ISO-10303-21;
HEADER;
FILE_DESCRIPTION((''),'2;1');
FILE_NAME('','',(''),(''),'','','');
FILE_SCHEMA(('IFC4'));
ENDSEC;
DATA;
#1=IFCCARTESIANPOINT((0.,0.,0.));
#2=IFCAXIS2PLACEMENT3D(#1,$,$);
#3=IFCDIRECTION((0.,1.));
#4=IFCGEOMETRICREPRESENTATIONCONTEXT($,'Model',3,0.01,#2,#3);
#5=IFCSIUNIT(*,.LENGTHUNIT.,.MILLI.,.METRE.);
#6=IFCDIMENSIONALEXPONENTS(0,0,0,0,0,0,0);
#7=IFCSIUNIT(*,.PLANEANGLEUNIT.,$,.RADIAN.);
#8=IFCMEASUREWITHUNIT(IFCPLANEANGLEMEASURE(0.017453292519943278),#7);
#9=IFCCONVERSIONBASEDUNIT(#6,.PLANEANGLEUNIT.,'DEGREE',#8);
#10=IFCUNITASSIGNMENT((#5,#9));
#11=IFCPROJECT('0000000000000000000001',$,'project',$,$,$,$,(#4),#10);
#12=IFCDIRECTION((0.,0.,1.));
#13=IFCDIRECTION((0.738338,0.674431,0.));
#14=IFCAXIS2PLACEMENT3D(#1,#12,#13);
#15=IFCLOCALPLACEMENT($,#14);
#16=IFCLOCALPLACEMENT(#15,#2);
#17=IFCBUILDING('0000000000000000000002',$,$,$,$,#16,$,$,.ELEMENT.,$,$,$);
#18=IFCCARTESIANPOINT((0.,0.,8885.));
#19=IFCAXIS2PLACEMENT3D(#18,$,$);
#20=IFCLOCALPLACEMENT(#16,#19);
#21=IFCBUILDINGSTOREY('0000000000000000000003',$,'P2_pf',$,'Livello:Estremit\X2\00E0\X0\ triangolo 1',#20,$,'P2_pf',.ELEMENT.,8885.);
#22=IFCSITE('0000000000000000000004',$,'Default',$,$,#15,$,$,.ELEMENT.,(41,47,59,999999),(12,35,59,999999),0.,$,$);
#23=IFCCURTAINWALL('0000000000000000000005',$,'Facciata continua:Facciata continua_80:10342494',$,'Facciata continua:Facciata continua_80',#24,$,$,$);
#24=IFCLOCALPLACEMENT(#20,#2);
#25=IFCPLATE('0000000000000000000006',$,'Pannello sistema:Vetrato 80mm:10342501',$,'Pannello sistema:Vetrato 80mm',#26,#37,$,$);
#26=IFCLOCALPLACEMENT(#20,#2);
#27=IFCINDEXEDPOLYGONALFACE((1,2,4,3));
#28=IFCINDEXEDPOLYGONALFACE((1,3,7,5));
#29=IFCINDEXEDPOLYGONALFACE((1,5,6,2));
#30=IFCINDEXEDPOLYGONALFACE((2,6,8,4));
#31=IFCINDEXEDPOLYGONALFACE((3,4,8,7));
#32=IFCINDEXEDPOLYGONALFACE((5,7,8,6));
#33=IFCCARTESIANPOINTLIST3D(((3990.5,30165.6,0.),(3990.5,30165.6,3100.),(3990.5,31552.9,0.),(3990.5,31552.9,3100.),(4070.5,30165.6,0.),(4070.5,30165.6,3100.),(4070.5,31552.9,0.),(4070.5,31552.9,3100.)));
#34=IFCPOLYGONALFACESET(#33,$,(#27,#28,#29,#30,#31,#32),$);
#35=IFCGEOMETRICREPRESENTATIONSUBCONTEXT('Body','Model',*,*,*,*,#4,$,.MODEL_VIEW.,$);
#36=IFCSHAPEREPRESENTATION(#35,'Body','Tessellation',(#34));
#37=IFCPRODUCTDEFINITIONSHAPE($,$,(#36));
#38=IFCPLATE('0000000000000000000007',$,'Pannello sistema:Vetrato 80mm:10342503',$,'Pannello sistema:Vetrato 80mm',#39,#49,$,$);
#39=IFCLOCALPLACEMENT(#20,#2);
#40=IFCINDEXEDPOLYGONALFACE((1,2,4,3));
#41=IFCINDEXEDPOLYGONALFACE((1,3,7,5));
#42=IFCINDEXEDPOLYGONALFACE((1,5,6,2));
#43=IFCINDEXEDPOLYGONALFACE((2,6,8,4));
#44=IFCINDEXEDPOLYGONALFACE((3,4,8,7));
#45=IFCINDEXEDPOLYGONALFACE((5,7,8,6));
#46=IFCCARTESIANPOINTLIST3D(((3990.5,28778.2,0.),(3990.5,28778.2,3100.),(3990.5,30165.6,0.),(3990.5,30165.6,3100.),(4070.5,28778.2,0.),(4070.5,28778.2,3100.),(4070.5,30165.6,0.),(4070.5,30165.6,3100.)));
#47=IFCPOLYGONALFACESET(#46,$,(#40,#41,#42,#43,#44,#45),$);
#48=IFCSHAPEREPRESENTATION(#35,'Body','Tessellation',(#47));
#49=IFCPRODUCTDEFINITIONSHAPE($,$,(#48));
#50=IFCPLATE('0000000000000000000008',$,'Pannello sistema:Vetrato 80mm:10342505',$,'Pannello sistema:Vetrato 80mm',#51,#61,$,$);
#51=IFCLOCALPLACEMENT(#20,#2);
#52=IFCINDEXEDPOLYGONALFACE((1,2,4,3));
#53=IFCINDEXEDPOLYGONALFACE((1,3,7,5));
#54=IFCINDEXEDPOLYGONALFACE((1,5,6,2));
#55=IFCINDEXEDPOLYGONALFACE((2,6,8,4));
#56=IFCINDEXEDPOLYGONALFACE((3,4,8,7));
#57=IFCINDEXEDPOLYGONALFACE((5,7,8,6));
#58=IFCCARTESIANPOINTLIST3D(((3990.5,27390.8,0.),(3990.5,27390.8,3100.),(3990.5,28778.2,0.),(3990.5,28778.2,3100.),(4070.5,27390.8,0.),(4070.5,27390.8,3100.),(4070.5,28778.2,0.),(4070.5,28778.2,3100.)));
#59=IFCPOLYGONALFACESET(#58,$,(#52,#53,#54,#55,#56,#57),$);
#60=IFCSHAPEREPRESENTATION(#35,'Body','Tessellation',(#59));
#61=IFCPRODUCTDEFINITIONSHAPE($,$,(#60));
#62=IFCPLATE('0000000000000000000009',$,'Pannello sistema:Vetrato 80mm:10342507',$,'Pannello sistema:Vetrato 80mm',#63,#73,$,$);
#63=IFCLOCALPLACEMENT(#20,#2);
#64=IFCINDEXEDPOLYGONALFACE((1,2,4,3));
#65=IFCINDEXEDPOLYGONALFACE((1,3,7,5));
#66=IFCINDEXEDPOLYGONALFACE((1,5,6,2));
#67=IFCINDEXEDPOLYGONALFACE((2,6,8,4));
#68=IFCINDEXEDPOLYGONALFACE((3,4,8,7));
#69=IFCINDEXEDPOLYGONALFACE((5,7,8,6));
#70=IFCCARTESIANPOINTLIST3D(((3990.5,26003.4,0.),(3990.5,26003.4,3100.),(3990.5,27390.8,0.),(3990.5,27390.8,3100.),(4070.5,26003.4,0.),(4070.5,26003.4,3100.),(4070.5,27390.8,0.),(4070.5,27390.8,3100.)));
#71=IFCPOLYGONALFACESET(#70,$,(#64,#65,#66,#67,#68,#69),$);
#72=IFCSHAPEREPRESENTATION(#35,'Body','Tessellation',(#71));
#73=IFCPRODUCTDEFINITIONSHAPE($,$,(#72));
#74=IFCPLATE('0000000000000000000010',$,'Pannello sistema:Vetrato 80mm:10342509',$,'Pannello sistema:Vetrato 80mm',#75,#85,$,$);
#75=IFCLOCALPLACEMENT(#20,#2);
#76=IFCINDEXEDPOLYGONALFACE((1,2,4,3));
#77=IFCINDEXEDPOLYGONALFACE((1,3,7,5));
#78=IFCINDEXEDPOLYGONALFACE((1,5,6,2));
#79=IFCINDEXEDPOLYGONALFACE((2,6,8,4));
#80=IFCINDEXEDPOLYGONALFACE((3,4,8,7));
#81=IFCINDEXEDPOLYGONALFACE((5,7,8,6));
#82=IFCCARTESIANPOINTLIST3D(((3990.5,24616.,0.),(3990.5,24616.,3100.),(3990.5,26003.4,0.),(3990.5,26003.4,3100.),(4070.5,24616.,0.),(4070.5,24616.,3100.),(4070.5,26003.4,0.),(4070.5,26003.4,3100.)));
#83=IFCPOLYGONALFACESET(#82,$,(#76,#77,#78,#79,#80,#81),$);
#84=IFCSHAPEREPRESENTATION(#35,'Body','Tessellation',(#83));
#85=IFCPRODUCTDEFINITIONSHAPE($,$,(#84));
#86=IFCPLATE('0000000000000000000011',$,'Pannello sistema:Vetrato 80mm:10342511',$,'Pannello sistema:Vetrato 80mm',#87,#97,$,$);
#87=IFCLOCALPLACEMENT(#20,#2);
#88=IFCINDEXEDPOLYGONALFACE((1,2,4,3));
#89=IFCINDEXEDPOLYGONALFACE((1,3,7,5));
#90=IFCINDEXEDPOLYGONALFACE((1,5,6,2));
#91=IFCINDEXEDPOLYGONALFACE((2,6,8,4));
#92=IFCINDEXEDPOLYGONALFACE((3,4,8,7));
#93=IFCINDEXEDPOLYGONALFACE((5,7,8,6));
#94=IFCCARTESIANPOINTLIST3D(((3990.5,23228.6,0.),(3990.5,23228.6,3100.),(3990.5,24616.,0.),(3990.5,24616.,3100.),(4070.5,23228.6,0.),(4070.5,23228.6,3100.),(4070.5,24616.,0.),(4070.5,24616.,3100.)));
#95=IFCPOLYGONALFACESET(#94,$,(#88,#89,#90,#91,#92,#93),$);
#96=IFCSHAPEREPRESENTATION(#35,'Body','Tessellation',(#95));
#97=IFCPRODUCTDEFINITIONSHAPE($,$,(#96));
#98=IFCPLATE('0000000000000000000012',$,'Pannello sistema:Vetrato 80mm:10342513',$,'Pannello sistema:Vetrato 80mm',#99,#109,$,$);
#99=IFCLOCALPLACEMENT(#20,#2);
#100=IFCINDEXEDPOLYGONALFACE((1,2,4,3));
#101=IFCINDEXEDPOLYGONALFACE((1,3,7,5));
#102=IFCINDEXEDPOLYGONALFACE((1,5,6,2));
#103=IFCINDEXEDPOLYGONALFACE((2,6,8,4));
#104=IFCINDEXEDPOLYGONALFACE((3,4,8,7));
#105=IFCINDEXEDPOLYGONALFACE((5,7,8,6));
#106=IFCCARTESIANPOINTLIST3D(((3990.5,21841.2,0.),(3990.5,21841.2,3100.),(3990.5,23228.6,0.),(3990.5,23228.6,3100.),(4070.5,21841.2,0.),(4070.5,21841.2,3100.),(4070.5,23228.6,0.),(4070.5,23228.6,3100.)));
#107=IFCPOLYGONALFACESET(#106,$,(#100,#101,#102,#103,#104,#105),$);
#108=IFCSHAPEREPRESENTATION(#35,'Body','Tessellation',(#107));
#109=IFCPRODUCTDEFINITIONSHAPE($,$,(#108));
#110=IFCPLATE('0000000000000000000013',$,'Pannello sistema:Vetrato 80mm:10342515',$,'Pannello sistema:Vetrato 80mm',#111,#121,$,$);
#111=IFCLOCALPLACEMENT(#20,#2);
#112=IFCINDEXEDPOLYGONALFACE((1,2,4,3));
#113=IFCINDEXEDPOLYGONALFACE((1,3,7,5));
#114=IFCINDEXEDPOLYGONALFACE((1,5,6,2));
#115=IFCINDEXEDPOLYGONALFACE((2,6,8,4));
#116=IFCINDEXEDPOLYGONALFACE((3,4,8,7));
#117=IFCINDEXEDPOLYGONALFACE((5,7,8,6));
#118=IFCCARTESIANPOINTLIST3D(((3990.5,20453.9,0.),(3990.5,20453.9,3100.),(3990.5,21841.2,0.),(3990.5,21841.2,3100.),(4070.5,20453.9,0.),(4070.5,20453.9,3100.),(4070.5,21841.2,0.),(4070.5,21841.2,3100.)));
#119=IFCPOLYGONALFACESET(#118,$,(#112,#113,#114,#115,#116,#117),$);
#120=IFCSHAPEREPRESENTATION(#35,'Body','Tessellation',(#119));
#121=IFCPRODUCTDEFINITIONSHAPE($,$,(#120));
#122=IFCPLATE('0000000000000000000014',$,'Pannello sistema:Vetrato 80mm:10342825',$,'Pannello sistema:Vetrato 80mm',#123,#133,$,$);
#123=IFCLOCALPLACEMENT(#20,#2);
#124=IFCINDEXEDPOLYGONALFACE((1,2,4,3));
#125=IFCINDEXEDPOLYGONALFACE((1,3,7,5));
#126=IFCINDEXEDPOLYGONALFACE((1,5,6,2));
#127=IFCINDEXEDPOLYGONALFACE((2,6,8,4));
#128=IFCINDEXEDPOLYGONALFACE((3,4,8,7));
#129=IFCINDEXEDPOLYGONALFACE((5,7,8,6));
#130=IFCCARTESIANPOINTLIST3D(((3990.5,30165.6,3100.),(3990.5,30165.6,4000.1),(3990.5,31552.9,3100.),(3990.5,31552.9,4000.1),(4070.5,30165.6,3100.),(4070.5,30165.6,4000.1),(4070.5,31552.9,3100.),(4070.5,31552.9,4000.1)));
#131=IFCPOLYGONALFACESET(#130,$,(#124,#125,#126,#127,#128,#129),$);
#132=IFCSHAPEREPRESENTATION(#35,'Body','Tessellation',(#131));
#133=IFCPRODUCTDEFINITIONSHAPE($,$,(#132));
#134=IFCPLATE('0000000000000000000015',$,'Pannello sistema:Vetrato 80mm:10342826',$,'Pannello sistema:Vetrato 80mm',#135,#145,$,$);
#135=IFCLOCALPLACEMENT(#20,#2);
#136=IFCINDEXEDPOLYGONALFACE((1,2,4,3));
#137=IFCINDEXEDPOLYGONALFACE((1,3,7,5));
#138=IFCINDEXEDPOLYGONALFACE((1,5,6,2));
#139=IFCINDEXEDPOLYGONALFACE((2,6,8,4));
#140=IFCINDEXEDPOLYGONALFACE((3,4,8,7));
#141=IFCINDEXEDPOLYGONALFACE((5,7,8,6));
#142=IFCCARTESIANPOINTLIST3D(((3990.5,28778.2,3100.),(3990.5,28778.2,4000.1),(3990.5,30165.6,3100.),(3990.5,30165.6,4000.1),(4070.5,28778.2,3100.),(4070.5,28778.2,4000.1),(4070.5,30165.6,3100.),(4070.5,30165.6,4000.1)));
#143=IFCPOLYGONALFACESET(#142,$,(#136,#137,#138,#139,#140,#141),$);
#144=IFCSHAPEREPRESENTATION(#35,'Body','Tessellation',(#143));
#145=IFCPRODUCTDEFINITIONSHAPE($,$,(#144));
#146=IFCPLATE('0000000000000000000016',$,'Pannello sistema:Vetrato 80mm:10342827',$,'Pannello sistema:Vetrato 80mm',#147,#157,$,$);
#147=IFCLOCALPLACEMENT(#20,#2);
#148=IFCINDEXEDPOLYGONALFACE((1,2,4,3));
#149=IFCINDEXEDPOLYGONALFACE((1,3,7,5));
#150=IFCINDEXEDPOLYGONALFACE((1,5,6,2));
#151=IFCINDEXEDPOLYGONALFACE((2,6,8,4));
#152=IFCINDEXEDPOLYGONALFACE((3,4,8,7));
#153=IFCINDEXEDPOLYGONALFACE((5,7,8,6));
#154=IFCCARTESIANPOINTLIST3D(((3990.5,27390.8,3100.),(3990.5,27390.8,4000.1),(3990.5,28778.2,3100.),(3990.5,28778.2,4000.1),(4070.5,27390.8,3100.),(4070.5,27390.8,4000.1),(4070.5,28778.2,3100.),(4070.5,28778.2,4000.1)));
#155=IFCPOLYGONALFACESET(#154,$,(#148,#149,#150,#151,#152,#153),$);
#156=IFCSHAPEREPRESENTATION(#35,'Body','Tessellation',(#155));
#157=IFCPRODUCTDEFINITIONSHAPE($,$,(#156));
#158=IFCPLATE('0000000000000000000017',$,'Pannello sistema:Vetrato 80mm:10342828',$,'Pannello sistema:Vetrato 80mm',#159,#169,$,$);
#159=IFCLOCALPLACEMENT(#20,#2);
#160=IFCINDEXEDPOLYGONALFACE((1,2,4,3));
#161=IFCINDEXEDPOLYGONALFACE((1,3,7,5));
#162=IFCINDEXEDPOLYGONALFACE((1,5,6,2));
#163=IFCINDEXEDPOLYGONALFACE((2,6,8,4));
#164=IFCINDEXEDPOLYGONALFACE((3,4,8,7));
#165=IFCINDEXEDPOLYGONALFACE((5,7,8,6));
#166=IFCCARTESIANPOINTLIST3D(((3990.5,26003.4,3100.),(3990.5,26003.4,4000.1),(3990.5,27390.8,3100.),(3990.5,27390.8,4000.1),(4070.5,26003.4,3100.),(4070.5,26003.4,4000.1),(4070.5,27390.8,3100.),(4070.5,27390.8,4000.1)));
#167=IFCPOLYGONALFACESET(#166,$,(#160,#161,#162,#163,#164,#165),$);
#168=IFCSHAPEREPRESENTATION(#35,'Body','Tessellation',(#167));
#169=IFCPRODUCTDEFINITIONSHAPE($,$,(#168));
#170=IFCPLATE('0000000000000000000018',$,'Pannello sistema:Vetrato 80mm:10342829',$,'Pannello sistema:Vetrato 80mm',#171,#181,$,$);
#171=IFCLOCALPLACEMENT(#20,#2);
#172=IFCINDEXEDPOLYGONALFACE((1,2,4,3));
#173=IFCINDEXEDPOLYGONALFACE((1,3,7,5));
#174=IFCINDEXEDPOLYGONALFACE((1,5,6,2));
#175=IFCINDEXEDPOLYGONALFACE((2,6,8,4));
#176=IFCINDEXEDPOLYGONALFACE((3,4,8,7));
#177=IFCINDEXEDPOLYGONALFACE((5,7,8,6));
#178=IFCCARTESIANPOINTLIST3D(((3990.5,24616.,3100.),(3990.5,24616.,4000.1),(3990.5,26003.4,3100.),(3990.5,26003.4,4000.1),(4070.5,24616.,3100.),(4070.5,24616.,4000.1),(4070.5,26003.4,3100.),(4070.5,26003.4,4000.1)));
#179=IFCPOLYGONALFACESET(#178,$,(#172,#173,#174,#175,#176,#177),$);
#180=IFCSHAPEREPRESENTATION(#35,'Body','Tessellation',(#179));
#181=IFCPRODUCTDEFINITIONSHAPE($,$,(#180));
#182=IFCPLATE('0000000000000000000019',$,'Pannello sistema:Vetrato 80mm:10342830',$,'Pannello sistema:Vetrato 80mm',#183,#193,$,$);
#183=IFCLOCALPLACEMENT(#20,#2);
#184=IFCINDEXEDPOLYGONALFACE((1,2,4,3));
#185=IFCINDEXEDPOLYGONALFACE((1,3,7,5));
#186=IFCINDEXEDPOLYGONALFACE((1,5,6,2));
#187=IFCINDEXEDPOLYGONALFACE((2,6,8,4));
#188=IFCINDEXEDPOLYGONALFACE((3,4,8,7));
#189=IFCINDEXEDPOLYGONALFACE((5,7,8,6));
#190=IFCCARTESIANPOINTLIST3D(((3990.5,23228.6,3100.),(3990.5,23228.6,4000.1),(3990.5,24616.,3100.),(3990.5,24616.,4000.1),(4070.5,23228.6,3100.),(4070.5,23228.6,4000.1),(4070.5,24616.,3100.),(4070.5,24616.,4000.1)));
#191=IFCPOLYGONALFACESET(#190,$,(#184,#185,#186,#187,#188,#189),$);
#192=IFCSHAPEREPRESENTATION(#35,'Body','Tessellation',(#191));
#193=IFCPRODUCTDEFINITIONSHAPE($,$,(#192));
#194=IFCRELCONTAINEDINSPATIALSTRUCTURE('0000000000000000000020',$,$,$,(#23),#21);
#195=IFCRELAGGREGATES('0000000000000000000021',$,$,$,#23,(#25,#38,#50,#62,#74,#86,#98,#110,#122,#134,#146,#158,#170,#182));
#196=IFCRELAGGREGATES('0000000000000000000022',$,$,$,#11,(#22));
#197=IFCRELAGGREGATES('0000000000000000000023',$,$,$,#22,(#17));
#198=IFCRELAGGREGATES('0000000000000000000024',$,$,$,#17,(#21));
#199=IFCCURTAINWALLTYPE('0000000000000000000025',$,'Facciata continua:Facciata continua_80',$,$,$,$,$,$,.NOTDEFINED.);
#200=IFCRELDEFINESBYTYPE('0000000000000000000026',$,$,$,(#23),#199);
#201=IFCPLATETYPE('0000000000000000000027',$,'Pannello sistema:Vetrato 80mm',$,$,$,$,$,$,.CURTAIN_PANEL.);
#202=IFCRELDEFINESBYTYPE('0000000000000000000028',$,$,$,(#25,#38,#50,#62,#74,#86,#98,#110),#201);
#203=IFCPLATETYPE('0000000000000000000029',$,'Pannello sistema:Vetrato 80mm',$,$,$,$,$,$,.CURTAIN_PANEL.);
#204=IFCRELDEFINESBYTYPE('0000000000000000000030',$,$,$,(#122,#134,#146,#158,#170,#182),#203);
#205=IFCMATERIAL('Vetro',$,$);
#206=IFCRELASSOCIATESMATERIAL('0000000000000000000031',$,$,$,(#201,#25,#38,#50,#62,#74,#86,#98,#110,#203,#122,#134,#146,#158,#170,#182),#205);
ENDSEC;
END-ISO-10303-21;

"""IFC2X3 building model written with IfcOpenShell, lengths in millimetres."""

from ifc_helpers import new_model, entity, si_unit, converted_unit, direction, frame, frame_2d, origin, place, context, subcontext, project, spatial, rectangle, extrude, source, transform, mapped, material, type_object, type_shapes, element, aggregate, save


model = new_model("IFC2X3")

# Units and contexts
model_context = context("Model", 3, precision=0.01, world=origin(), true_north=direction((0.0, 1.0)))
body_context = subcontext(model_context, "Body", "Model", "MODEL_VIEW")
ifc_project = project(units=[si_unit("LENGTHUNIT", "METRE", prefix="MILLI"), converted_unit("PLANEANGLEUNIT", "DEGREE", entity("IfcPlaneAngleMeasure", 0.017453292519943278), si_unit("PLANEANGLEUNIT", "RADIAN"), dimensions=[0, 0, 0, 0, 0, 0, 0])], contexts=[model_context])

# Site, building, storey
site_placement = place(None, frame((0.0, 0.0, 0.0), z_axis=(0.0, 0.0, 1.0), x_axis=(0.738338, 0.674431, 0.0)))
site = spatial("IfcSite", under=ifc_project, at=site_placement, Name="Default", CompositionType="ELEMENT", RefLatitude=(41, 47, 59, 999999), RefLongitude=(12, 35, 59, 999999), RefElevation=0.0)
building_placement = place(site_placement, origin())
building = spatial("IfcBuilding", under=site, at=building_placement, CompositionType="ELEMENT")
storey_placement = place(building_placement, frame((0.0, 0.0, 8885.0)))
storey = spatial("IfcBuildingStorey", under=building, at=storey_placement, Name="P2_pf", ObjectType="Livello:Estremità triangolo 1", LongName="P2_pf", CompositionType="ELEMENT", Elevation=8885.0)

# Curtain wall, plates
curtain_wall_type = type_object("IfcCurtainWallType", Name="Facciata continua:Facciata continua_80", PredefinedType="NOTDEFINED")
curtain_wall_placement = place(storey_placement, frame((0.0, 0.0, -8885.0)))
curtain_wall = element("IfcCurtainWall", 1, at=curtain_wall_placement, inside=storey, type_object=curtain_wall_type, Name="Facciata continua:Facciata continua_80:10342494", ObjectType="Facciata continua:Facciata continua_80")
ifc_material_1 = material(Name="Vetro")
plate_type_1 = type_object("IfcPlateType", Name="Pannello sistema:Vetrato 80mm", PredefinedType="CURTAIN_PANEL", material=ifc_material_1)
shared_shape_1 = source(origin(), body_context, "Body", "SweptSolid", [
    extrude(rectangle(XDim=80.0, YDim=1387.4, at=frame_2d((0.0, 0.0), x_axis=(1.0, 0.0))), frame((0.0, -40.0, 0.0), z_axis=(0.0, 0.0, 1.0), x_axis=(0.0, 1.0, 0.0)), (0.0, 0.0, 1.0), 3100.0),
])
type_shapes(plate_type_1, [shared_shape_1])
plate_1_placement = place(curtain_wall_placement, frame((4070.5, 30859.3, 8885.0), z_axis=(0.0, 0.0, 1.0), x_axis=(0.0, -1.0, 0.0)))
plate_1 = element("IfcPlate", 2, at=plate_1_placement, type_object=plate_type_1, material=ifc_material_1, Name="Pannello sistema:Vetrato 80mm:10342501", ObjectType="Pannello sistema:Vetrato 80mm", context=body_context, shape_type="MappedRepresentation", body=[
    mapped(shared_shape_1, transform((0.0, 0.0, 0.0), scale=1.0)),
])
plate_2_placement = place(curtain_wall_placement, frame((4070.5, 29471.9, 8885.0), z_axis=(0.0, 0.0, 1.0), x_axis=(0.0, -1.0, 0.0)))
plate_2 = element("IfcPlate", 3, at=plate_2_placement, type_object=plate_type_1, material=ifc_material_1, Name="Pannello sistema:Vetrato 80mm:10342503", ObjectType="Pannello sistema:Vetrato 80mm", context=body_context, shape_type="MappedRepresentation", body=[
    mapped(shared_shape_1, transform((0.0, 0.0, 0.0), scale=1.0)),
])
plate_3_placement = place(curtain_wall_placement, frame((4070.5, 28084.5, 8885.0), z_axis=(0.0, 0.0, 1.0), x_axis=(0.0, -1.0, 0.0)))
plate_3 = element("IfcPlate", 4, at=plate_3_placement, type_object=plate_type_1, material=ifc_material_1, Name="Pannello sistema:Vetrato 80mm:10342505", ObjectType="Pannello sistema:Vetrato 80mm", context=body_context, shape_type="MappedRepresentation", body=[
    mapped(shared_shape_1, transform((0.0, 0.0, 0.0), scale=1.0)),
])
plate_4_placement = place(curtain_wall_placement, frame((4070.5, 26697.1, 8885.0), z_axis=(0.0, 0.0, 1.0), x_axis=(0.0, -1.0, 0.0)))
plate_4 = element("IfcPlate", 5, at=plate_4_placement, type_object=plate_type_1, material=ifc_material_1, Name="Pannello sistema:Vetrato 80mm:10342507", ObjectType="Pannello sistema:Vetrato 80mm", context=body_context, shape_type="MappedRepresentation", body=[
    mapped(shared_shape_1, transform((0.0, 0.0, 0.0), scale=1.0)),
])
plate_5_placement = place(curtain_wall_placement, frame((4070.5, 25309.7, 8885.0), z_axis=(0.0, 0.0, 1.0), x_axis=(0.0, -1.0, 0.0)))
plate_5 = element("IfcPlate", 6, at=plate_5_placement, type_object=plate_type_1, material=ifc_material_1, Name="Pannello sistema:Vetrato 80mm:10342509", ObjectType="Pannello sistema:Vetrato 80mm", context=body_context, shape_type="MappedRepresentation", body=[
    mapped(shared_shape_1, transform((0.0, 0.0, 0.0), scale=1.0)),
])
plate_6_placement = place(curtain_wall_placement, frame((4070.5, 23922.3, 8885.0), z_axis=(0.0, 0.0, 1.0), x_axis=(0.0, -1.0, 0.0)))
plate_6 = element("IfcPlate", 7, at=plate_6_placement, type_object=plate_type_1, material=ifc_material_1, Name="Pannello sistema:Vetrato 80mm:10342511", ObjectType="Pannello sistema:Vetrato 80mm", context=body_context, shape_type="MappedRepresentation", body=[
    mapped(shared_shape_1, transform((0.0, 0.0, 0.0), scale=1.0)),
])
plate_7_placement = place(curtain_wall_placement, frame((4070.5, 22534.9, 8885.0), z_axis=(0.0, 0.0, 1.0), x_axis=(0.0, -1.0, 0.0)))
plate_7 = element("IfcPlate", 8, at=plate_7_placement, type_object=plate_type_1, material=ifc_material_1, Name="Pannello sistema:Vetrato 80mm:10342513", ObjectType="Pannello sistema:Vetrato 80mm", context=body_context, shape_type="MappedRepresentation", body=[
    mapped(shared_shape_1, transform((0.0, 0.0, 0.0), scale=1.0)),
])
plate_8_placement = place(curtain_wall_placement, frame((4070.5, 21147.6, 8885.0), z_axis=(0.0, 0.0, 1.0), x_axis=(0.0, -1.0, 0.0)))
plate_8 = element("IfcPlate", 9, at=plate_8_placement, type_object=plate_type_1, material=ifc_material_1, Name="Pannello sistema:Vetrato 80mm:10342515", ObjectType="Pannello sistema:Vetrato 80mm", context=body_context, shape_type="MappedRepresentation", body=[
    mapped(shared_shape_1, transform((0.0, 0.0, 0.0), scale=1.0)),
])
plate_type_2 = type_object("IfcPlateType", Name="Pannello sistema:Vetrato 80mm", PredefinedType="CURTAIN_PANEL", material=ifc_material_1)
shared_shape_2 = source(origin(), body_context, "Body", "SweptSolid", [
    extrude(rectangle(XDim=80.0, YDim=1387.4, at=frame_2d((0.0, 0.0), x_axis=(1.0, 0.0))), frame((0.0, -40.0, 0.0), z_axis=(0.0, 0.0, 1.0), x_axis=(0.0, 1.0, 0.0)), (0.0, 0.0, 1.0), 900.1),
])
type_shapes(plate_type_2, [shared_shape_2])
plate_9_placement = place(curtain_wall_placement, frame((4070.5, 30859.3, 11985.0), z_axis=(0.0, 0.0, 1.0), x_axis=(0.0, -1.0, 0.0)))
plate_9 = element("IfcPlate", 10, at=plate_9_placement, type_object=plate_type_2, material=ifc_material_1, Name="Pannello sistema:Vetrato 80mm:10342825", ObjectType="Pannello sistema:Vetrato 80mm", context=body_context, shape_type="MappedRepresentation", body=[
    mapped(shared_shape_2, transform((0.0, 0.0, 0.0), scale=1.0)),
])
plate_10_placement = place(curtain_wall_placement, frame((4070.5, 29471.9, 11985.0), z_axis=(0.0, 0.0, 1.0), x_axis=(0.0, -1.0, 0.0)))
plate_10 = element("IfcPlate", 11, at=plate_10_placement, type_object=plate_type_2, material=ifc_material_1, Name="Pannello sistema:Vetrato 80mm:10342826", ObjectType="Pannello sistema:Vetrato 80mm", context=body_context, shape_type="MappedRepresentation", body=[
    mapped(shared_shape_2, transform((0.0, 0.0, 0.0), scale=1.0)),
])
plate_11_placement = place(curtain_wall_placement, frame((4070.5, 28084.5, 11985.0), z_axis=(0.0, 0.0, 1.0), x_axis=(0.0, -1.0, 0.0)))
plate_11 = element("IfcPlate", 12, at=plate_11_placement, type_object=plate_type_2, material=ifc_material_1, Name="Pannello sistema:Vetrato 80mm:10342827", ObjectType="Pannello sistema:Vetrato 80mm", context=body_context, shape_type="MappedRepresentation", body=[
    mapped(shared_shape_2, transform((0.0, 0.0, 0.0), scale=1.0)),
])
plate_12_placement = place(curtain_wall_placement, frame((4070.5, 26697.1, 11985.0), z_axis=(0.0, 0.0, 1.0), x_axis=(0.0, -1.0, 0.0)))
plate_12 = element("IfcPlate", 13, at=plate_12_placement, type_object=plate_type_2, material=ifc_material_1, Name="Pannello sistema:Vetrato 80mm:10342828", ObjectType="Pannello sistema:Vetrato 80mm", context=body_context, shape_type="MappedRepresentation", body=[
    mapped(shared_shape_2, transform((0.0, 0.0, 0.0), scale=1.0)),
])
plate_13_placement = place(curtain_wall_placement, frame((4070.5, 25309.7, 11985.0), z_axis=(0.0, 0.0, 1.0), x_axis=(0.0, -1.0, 0.0)))
plate_13 = element("IfcPlate", 14, at=plate_13_placement, type_object=plate_type_2, material=ifc_material_1, Name="Pannello sistema:Vetrato 80mm:10342829", ObjectType="Pannello sistema:Vetrato 80mm", context=body_context, shape_type="MappedRepresentation", body=[
    mapped(shared_shape_2, transform((0.0, 0.0, 0.0), scale=1.0)),
])
plate_14_placement = place(curtain_wall_placement, frame((4070.5, 23922.3, 11985.0), z_axis=(0.0, 0.0, 1.0), x_axis=(0.0, -1.0, 0.0)))
plate_14 = element("IfcPlate", 15, at=plate_14_placement, type_object=plate_type_2, material=ifc_material_1, Name="Pannello sistema:Vetrato 80mm:10342830", ObjectType="Pannello sistema:Vetrato 80mm", context=body_context, shape_type="MappedRepresentation", body=[
    mapped(shared_shape_2, transform((0.0, 0.0, 0.0), scale=1.0)),
])
aggregate(curtain_wall, [plate_1, plate_2, plate_3, plate_4, plate_5, plate_6, plate_7, plate_8, plate_9, plate_10, plate_11, plate_12, plate_13, plate_14])

save(model, "model.ifc")
